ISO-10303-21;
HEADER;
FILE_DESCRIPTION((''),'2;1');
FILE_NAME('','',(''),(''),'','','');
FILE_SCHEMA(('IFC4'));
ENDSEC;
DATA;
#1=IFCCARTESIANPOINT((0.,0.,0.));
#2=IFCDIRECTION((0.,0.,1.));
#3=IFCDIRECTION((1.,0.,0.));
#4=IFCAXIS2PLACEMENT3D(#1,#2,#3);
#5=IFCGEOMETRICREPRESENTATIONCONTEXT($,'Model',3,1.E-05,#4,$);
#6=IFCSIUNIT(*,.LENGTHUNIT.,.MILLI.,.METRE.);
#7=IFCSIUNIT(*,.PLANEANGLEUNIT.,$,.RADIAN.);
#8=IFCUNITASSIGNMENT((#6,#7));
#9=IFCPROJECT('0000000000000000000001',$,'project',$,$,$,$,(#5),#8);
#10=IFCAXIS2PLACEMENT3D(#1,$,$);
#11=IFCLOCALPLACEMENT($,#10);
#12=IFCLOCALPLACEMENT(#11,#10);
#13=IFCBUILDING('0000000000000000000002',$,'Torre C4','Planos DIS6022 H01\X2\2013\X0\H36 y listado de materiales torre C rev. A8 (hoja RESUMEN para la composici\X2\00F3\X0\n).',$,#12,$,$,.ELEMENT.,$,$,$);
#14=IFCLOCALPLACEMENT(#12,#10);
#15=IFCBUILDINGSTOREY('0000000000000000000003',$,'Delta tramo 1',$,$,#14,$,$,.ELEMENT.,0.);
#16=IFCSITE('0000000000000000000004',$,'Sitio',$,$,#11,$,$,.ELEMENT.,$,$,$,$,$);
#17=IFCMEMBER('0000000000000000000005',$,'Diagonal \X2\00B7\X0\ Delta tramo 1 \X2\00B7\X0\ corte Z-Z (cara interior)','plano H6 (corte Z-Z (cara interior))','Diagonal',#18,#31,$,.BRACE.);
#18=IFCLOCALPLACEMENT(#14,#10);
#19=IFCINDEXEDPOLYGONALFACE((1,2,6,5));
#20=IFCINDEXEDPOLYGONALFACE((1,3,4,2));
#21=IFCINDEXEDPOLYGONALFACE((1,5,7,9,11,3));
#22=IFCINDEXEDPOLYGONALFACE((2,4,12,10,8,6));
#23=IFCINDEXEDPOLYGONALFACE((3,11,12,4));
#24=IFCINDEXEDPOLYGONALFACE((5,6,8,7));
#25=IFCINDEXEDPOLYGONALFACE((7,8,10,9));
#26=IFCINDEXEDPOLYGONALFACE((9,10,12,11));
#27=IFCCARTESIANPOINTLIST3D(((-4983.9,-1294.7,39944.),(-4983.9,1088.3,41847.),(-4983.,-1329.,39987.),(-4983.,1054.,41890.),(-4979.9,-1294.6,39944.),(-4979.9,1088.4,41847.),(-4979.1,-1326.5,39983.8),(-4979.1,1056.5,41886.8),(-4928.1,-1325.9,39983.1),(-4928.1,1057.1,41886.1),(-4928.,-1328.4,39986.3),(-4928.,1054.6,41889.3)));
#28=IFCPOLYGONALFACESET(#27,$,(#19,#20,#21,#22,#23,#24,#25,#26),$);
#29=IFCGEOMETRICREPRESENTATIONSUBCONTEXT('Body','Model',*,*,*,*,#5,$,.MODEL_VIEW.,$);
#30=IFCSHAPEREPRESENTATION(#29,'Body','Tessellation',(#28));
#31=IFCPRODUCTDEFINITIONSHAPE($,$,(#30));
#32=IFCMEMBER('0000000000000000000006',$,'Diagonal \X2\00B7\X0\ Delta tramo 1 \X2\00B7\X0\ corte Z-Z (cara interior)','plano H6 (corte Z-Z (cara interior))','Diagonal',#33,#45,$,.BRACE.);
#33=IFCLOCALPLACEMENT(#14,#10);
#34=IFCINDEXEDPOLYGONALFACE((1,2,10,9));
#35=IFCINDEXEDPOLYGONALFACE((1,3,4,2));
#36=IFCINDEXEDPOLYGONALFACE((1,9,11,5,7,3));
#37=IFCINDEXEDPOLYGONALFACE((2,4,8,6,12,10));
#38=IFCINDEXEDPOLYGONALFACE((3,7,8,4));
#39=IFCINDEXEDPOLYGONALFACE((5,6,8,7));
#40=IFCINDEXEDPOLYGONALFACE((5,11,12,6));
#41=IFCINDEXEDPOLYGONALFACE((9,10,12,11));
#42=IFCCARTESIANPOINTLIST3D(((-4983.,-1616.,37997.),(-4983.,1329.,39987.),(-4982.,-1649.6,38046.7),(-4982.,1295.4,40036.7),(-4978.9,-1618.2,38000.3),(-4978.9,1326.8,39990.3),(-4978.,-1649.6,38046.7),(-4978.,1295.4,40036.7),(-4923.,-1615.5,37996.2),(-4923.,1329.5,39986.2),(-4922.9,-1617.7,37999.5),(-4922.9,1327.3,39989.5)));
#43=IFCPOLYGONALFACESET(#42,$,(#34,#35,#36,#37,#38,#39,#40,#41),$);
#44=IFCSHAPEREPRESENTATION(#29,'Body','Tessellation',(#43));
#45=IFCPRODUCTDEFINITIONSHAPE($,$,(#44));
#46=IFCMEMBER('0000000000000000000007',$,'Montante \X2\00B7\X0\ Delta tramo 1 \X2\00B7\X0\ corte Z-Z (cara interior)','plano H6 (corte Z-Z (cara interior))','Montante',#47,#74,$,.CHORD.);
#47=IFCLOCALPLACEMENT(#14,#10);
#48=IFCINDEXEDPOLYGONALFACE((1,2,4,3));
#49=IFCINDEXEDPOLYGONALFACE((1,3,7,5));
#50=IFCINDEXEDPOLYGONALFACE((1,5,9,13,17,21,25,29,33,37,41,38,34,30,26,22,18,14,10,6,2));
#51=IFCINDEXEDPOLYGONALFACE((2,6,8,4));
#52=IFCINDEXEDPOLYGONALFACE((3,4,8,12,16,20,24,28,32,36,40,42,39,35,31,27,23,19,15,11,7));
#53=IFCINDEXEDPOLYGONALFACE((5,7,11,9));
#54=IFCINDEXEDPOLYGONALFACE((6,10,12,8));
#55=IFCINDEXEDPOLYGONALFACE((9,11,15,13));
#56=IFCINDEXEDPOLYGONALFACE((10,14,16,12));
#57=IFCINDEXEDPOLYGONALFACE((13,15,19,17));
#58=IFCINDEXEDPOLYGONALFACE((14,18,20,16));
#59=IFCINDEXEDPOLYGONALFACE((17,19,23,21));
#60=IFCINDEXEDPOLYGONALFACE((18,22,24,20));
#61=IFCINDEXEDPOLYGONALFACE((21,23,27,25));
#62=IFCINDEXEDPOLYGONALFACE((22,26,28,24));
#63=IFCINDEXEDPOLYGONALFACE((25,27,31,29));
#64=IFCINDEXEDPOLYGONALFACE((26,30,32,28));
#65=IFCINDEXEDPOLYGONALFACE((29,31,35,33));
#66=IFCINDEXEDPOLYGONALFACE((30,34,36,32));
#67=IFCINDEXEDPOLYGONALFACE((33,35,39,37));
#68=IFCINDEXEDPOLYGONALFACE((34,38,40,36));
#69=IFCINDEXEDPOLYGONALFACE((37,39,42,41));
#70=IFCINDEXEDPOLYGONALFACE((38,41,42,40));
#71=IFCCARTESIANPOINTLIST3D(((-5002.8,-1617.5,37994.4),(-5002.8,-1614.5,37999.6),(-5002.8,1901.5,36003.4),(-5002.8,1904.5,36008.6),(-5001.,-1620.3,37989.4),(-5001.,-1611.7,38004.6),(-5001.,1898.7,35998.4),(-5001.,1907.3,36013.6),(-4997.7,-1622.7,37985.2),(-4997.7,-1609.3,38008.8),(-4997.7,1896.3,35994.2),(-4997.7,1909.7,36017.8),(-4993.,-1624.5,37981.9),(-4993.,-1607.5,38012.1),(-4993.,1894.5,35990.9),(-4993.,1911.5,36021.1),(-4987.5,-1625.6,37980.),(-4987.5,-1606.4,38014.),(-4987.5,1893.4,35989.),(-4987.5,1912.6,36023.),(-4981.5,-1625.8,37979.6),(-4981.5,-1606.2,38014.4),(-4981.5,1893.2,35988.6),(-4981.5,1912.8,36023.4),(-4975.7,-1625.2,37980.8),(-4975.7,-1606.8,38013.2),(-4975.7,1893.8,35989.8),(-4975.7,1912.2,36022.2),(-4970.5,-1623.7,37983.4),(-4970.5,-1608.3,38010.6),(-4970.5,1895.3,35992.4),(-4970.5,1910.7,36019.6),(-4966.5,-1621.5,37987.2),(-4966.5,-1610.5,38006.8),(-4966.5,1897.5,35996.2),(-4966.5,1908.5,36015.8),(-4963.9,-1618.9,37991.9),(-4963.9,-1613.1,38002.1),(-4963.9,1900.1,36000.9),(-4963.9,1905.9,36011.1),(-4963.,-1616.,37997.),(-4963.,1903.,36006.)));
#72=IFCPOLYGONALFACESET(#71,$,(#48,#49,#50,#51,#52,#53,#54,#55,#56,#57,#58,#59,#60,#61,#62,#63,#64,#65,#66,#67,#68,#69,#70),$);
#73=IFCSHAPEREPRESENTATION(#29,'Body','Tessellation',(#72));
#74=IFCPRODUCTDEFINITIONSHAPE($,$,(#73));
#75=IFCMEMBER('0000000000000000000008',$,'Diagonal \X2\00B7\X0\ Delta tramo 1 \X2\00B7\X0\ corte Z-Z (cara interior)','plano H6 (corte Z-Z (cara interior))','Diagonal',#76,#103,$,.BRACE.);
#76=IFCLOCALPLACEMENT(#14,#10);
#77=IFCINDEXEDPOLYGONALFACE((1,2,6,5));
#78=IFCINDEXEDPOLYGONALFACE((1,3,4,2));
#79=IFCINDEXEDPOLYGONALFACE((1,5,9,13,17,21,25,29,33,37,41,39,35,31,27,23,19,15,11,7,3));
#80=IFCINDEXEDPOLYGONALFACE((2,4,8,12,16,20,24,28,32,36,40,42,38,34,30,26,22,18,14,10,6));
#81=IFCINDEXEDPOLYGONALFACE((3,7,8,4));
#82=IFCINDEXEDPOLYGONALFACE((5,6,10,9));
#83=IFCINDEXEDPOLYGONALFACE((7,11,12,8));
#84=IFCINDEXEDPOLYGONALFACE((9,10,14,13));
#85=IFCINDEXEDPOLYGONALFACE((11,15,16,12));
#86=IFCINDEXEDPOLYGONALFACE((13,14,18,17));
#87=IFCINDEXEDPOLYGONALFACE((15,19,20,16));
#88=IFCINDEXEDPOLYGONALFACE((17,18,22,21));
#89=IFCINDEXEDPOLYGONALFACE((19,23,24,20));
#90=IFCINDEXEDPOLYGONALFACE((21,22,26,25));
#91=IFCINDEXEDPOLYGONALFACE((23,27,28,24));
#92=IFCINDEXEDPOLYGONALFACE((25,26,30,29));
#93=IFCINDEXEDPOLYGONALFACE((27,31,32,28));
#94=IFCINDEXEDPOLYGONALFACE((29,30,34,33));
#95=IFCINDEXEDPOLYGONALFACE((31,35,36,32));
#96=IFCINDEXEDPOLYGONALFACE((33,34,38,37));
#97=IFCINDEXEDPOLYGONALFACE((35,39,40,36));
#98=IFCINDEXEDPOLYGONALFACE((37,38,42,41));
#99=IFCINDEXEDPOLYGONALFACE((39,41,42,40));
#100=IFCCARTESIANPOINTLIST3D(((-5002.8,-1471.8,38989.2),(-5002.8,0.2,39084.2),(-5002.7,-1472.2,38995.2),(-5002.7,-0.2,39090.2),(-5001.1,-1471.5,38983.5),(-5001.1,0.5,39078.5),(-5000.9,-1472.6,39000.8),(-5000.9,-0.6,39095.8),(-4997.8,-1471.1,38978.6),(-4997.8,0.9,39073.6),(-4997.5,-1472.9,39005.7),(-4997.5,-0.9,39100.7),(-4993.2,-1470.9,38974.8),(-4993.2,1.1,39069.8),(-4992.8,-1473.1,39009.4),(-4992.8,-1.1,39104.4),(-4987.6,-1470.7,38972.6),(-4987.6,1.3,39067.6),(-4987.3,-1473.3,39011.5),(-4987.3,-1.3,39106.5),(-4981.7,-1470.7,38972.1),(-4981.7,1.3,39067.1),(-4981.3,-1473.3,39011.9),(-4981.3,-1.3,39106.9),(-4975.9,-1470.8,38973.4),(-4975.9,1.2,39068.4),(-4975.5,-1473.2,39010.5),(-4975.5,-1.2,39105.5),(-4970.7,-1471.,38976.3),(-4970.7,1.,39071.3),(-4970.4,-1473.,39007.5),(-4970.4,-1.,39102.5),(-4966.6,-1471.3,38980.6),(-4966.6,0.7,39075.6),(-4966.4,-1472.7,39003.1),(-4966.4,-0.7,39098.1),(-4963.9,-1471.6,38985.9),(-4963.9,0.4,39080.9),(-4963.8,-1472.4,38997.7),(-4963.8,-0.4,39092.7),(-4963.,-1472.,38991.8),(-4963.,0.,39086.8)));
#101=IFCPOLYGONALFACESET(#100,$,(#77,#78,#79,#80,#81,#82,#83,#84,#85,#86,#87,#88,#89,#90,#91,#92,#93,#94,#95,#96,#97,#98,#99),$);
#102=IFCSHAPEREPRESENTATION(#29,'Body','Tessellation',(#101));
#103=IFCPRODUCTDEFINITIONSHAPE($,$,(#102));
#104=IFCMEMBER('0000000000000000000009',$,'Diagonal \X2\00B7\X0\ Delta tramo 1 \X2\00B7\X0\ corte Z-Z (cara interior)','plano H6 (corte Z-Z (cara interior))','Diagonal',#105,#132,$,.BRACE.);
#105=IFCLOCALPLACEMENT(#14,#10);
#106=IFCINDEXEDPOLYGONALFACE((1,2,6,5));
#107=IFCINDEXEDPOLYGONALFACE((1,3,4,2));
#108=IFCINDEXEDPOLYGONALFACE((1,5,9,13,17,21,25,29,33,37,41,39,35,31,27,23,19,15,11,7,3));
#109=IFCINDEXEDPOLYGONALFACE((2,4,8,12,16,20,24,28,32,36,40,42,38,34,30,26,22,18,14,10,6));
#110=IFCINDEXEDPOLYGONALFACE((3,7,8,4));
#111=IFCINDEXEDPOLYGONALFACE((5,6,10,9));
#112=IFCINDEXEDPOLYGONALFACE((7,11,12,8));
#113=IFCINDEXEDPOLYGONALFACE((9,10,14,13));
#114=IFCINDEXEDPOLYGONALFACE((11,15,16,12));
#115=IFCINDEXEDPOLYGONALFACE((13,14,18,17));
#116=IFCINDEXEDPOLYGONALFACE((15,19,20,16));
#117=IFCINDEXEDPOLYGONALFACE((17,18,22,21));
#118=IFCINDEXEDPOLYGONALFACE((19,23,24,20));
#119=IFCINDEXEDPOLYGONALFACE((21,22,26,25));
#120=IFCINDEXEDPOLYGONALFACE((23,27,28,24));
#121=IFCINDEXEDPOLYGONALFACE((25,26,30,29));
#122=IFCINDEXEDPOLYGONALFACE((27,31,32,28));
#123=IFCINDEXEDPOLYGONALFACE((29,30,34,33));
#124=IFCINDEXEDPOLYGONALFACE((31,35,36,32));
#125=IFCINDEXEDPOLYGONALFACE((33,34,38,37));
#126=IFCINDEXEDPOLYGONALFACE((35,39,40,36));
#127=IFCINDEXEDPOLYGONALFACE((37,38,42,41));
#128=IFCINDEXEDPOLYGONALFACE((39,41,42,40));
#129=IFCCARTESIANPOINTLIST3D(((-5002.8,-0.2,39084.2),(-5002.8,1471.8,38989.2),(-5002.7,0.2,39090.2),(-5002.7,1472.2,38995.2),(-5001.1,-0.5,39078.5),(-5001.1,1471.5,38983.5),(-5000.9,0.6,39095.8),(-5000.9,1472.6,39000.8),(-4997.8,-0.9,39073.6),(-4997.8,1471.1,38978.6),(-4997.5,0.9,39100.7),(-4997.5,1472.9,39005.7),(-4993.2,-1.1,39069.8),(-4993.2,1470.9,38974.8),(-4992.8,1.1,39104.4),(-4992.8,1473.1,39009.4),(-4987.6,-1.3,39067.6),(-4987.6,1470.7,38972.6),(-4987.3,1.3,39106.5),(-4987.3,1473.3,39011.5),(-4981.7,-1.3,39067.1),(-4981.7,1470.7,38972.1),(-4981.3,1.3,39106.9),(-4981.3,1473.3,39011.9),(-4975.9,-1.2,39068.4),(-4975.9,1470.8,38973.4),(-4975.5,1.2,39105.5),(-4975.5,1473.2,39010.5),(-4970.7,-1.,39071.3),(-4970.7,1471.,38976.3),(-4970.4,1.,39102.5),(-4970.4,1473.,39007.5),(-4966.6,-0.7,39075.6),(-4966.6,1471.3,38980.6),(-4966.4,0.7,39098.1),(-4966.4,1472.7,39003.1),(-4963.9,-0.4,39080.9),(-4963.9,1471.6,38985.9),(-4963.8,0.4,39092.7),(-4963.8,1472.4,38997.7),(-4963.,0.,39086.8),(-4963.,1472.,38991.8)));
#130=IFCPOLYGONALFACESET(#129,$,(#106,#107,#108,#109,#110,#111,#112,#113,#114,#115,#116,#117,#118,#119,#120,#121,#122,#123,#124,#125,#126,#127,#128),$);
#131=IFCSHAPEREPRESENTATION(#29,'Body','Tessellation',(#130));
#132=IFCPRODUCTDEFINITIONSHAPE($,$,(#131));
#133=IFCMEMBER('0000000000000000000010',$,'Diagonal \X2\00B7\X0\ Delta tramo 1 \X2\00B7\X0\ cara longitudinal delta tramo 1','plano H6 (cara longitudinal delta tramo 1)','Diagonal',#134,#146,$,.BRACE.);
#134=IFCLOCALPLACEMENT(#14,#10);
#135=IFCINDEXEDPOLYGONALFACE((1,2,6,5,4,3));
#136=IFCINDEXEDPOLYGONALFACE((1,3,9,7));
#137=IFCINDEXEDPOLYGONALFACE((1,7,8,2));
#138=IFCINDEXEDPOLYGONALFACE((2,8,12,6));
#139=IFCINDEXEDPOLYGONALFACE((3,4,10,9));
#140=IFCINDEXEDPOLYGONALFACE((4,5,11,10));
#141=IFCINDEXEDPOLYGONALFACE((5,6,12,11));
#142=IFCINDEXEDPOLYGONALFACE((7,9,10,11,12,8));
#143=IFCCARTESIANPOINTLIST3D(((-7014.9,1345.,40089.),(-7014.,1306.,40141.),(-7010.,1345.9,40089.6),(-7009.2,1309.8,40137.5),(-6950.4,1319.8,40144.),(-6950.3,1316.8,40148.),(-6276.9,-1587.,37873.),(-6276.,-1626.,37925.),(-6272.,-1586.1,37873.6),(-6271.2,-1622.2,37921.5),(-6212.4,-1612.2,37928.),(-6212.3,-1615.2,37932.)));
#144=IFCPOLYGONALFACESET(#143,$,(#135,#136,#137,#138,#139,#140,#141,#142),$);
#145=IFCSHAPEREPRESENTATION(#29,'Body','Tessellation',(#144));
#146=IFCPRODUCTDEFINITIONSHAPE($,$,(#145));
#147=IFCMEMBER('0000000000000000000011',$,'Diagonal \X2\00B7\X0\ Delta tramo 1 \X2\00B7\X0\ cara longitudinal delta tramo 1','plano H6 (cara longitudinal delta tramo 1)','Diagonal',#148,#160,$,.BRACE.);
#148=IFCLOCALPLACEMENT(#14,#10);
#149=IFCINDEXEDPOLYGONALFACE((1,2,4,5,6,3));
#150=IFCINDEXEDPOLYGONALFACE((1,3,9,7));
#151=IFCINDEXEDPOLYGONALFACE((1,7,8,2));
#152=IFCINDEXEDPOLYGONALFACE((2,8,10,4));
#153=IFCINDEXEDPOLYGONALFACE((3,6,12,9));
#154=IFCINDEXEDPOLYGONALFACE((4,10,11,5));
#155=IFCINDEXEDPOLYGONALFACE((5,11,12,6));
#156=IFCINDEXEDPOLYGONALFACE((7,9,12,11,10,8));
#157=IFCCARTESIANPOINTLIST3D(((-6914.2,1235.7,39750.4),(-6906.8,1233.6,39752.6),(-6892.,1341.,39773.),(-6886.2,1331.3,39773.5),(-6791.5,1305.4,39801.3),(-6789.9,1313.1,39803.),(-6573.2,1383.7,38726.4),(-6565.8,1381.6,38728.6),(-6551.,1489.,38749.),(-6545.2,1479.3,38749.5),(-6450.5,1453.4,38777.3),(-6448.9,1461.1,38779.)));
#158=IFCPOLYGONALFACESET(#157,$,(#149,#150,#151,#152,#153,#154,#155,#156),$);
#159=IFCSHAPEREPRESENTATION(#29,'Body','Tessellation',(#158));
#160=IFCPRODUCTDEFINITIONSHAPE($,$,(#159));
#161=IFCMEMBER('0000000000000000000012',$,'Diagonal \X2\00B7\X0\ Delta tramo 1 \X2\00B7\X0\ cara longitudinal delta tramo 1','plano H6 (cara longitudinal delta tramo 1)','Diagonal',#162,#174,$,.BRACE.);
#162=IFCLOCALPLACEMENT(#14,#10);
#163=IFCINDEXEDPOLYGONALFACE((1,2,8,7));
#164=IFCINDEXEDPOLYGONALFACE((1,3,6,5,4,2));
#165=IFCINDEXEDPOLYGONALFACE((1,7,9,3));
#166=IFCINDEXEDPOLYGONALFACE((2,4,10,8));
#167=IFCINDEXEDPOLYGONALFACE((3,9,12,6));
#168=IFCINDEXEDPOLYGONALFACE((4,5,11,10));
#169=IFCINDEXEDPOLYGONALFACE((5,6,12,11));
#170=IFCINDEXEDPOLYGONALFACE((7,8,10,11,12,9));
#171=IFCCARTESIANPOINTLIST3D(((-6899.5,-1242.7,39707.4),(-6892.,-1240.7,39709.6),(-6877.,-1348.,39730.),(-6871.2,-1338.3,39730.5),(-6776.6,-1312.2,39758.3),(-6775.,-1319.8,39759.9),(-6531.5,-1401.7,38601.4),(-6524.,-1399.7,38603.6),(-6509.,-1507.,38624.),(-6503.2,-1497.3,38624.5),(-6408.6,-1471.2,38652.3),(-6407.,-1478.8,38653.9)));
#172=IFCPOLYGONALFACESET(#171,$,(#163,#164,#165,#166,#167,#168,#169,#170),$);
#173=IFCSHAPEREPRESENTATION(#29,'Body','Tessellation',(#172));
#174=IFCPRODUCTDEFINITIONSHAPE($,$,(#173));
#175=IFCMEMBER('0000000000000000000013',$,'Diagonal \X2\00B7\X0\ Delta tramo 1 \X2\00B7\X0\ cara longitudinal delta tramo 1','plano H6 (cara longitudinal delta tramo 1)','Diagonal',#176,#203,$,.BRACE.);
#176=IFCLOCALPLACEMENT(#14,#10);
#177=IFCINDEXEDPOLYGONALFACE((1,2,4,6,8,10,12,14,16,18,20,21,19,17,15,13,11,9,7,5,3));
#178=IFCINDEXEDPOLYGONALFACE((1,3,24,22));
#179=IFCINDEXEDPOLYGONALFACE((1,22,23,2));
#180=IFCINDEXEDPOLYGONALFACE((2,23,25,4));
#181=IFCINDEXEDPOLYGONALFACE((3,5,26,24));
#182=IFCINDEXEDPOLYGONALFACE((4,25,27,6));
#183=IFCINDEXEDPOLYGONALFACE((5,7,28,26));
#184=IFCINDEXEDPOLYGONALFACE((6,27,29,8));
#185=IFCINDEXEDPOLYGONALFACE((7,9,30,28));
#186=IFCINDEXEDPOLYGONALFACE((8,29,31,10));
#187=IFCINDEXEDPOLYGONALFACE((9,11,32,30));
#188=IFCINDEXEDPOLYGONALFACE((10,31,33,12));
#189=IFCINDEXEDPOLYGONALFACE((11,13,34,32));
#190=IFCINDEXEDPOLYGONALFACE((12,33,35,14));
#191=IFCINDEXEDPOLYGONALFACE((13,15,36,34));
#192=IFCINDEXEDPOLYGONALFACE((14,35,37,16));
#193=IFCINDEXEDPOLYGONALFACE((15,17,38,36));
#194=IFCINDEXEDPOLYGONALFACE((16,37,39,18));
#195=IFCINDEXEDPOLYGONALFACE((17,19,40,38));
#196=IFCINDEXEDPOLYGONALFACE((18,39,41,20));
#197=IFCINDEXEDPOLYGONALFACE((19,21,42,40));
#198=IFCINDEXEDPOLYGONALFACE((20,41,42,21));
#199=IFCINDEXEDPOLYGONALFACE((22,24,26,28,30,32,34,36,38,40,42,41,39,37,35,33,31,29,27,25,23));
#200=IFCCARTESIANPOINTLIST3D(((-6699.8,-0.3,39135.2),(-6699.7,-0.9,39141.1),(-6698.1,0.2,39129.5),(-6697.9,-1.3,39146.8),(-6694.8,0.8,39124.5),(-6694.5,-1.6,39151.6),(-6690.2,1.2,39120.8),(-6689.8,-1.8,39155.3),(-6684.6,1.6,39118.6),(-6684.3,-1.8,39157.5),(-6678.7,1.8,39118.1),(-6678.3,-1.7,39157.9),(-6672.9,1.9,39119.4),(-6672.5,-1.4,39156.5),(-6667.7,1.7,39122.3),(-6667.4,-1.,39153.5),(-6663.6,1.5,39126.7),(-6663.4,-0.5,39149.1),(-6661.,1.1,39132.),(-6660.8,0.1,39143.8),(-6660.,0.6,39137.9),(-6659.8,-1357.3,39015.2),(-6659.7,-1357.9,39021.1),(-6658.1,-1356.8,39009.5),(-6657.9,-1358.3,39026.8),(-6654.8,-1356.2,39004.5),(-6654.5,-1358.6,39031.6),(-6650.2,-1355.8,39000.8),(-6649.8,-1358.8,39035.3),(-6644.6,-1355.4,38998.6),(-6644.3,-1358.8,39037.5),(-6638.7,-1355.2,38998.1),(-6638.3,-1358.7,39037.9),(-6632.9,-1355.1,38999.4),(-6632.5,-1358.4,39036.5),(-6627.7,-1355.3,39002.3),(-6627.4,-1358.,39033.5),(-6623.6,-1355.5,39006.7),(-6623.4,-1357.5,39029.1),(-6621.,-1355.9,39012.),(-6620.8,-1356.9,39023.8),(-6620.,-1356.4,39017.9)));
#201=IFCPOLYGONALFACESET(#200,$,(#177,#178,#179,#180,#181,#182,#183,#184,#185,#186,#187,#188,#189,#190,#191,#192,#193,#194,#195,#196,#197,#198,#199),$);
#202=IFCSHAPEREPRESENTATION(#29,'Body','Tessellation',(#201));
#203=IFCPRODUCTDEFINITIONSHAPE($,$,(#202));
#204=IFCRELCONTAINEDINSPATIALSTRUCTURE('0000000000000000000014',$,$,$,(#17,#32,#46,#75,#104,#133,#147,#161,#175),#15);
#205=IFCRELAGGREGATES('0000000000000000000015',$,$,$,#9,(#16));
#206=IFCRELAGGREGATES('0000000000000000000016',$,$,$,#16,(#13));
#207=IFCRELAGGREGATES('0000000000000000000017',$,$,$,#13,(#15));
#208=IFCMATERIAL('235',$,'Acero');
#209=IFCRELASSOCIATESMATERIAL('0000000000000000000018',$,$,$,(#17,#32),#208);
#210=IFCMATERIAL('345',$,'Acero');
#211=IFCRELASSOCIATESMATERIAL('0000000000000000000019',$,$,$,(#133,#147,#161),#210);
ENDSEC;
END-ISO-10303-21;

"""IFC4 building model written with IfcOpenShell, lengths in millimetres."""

from ifc_helpers import new_model, si_unit, frame, frame_2d, origin, origin_with_axes, place, context, subcontext, project, spatial, circle, l_section, extrude, material, element, save


model = new_model("IFC4")

# Units and contexts
model_context = context("Model", 3, precision=1e-05, world=origin_with_axes())
body_context = subcontext(model_context, "Body", "Model", "MODEL_VIEW")
ifc_project = project(units=[si_unit("LENGTHUNIT", "METRE", prefix="MILLI"), si_unit("PLANEANGLEUNIT", "RADIAN")], contexts=[model_context])

# Site, building, storey
site_placement = place(None, origin())
site = spatial("IfcSite", under=ifc_project, at=site_placement, Name="Sitio", CompositionType="ELEMENT")
building_placement = place(site_placement, origin())
building = spatial("IfcBuilding", under=site, at=building_placement, Name="Torre C4", Description="Planos DIS6022 H01–H36 y listado de materiales torre C rev. A8 (hoja RESUMEN para la composición).", CompositionType="ELEMENT")
storey_placement = place(building_placement, origin())
storey = spatial("IfcBuildingStorey", under=building, at=storey_placement, Name="Delta tramo 1", CompositionType="ELEMENT", Elevation=0.0)

# Members
ifc_material_1 = material(Name="345", Category="Acero")
ifc_material_2 = material(Name="235", Category="Acero")
member_1_placement = place(storey_placement, frame((-4983.0, -1329.0, 39987.0), z_axis=(0.0, 0.781412, 0.624015), x_axis=(0.999852, 0.010743, -0.013453)))
element("IfcMember", 1, at=member_1_placement, inside=storey, material=ifc_material_2, Name="Diagonal · Delta tramo 1 · corte Z-Z (cara interior)", Description="plano H6 (corte Z-Z (cara interior))", ObjectType="Diagonal", PredefinedType="BRACE", context=body_context, shape_type="SweptSolid", body=[
    extrude(l_section(Depth=55.0, Width=55.0, Thickness=4.0, at=frame_2d((27.5, 27.5))), None, (0.0, 0.0, 1.0), 3049.6),
])
member_2_placement = place(storey_placement, frame((-4983.0, 1329.0, 39987.0), z_axis=(0.0, -0.828571, -0.559884), x_axis=(0.99987, 0.009026, -0.013358)))
element("IfcMember", 2, at=member_2_placement, inside=storey, material=ifc_material_2, Name="Diagonal · Delta tramo 1 · corte Z-Z (cara interior)", Description="plano H6 (corte Z-Z (cara interior))", ObjectType="Diagonal", PredefinedType="BRACE", context=body_context, shape_type="SweptSolid", body=[
    extrude(l_section(Depth=60.0, Width=60.0, Thickness=4.0, at=frame_2d((30.0, 30.0))), None, (0.0, 0.0, 1.0), 3554.3),
])
member_3_placement = place(storey_placement, frame((-4983.0, -1616.0, 37997.0), z_axis=(0.0, 0.870351, -0.492432), x_axis=(1.0, 0.0, 0.0)))
element("IfcMember", 3, at=member_3_placement, inside=storey, Name="Montante · Delta tramo 1 · corte Z-Z (cara interior)", Description="plano H6 (corte Z-Z (cara interior))", ObjectType="Montante", PredefinedType="CHORD", context=body_context, shape_type="SweptSolid", body=[
    extrude(circle(Radius=20.0), None, (0.0, 0.0, 1.0), 4043.2),
])
for number, where, z_axis, x_axis, name in (
    (4, (-4983.0, -1472.0, 38992.0), (0.0, 0.997924, 0.064404), (0.999955, 0.000613, -0.009492), "Diagonal · Delta tramo 1 · corte Z-Z (cara interior)"),
    (5, (-4983.0, 1472.0, 38992.0), (0.0, -0.997924, 0.064404), (0.999955, -0.000613, -0.009492), "Diagonal · Delta tramo 1 · corte Z-Z (cara interior)"),
):
    element("IfcMember", number, at=place(storey_placement, frame(where, z_axis=z_axis, x_axis=x_axis)), inside=storey, Name=name, Description="plano H6 (corte Z-Z (cara interior))", ObjectType="Diagonal", PredefinedType="BRACE", context=body_context, shape_type="SweptSolid", body=[
        extrude(circle(Radius=20.0), None, (0.0, 0.0, 1.0), 1475.1),
    ])
member_4_placement = place(storey_placement, frame((-6276.0, -1626.0, 37925.0), z_axis=(-0.196874, 0.782161, 0.591156), x_axis=(0.980322, 0.165937, 0.106927)))
element("IfcMember", 6, at=member_4_placement, inside=storey, material=ifc_material_1, Name="Diagonal · Delta tramo 1 · cara longitudinal delta tramo 1", Description="plano H6 (cara longitudinal delta tramo 1)", ObjectType="Diagonal", PredefinedType="BRACE", context=body_context, shape_type="SweptSolid", body=[
    extrude(l_section(Depth=65.0, Width=65.0, Thickness=5.0, at=frame_2d((32.5, 32.5))), None, (0.0, 0.0, 1.0), 3748.6),
])
member_5_placement = place(storey_placement, frame((-6892.0, 1341.0, 39773.0), z_axis=(0.31302, 0.135856, -0.939979), x_axis=(0.928102, -0.253844, 0.272377)))
element("IfcMember", 7, at=member_5_placement, inside=storey, material=ifc_material_1, Name="Diagonal · Delta tramo 1 · cara longitudinal delta tramo 1", Description="plano H6 (cara longitudinal delta tramo 1)", ObjectType="Diagonal", PredefinedType="BRACE", context=body_context, shape_type="SweptSolid", body=[
    extrude(l_section(Depth=110.0, Width=110.0, Thickness=8.0, at=frame_2d((55.0, 55.0))), None, (0.0, 0.0, 1.0), 1089.4),
])
member_6_placement = place(storey_placement, frame((-6509.0, -1507.0, 38624.0), z_axis=(-0.312816, 0.135157, 0.940148), x_axis=(0.927617, 0.25621, 0.271813)))
element("IfcMember", 8, at=member_6_placement, inside=storey, material=ifc_material_1, Name="Diagonal · Delta tramo 1 · cara longitudinal delta tramo 1", Description="plano H6 (cara longitudinal delta tramo 1)", ObjectType="Diagonal", PredefinedType="BRACE", context=body_context, shape_type="SweptSolid", body=[
    extrude(l_section(Depth=110.0, Width=110.0, Thickness=8.0, at=frame_2d((55.0, 55.0))), None, (0.0, 0.0, 1.0), 1176.4),
])
for number, where, z_axis, x_axis, name in (
    (9, (-6680.0, 0.0, 39138.0), (0.02935, -0.995684, -0.088049), (0.999529, 0.030023, -0.006331), "Diagonal · Delta tramo 1 · cara longitudinal delta tramo 1"),
):
    element("IfcMember", number, at=place(storey_placement, frame(where, z_axis=z_axis, x_axis=x_axis)), inside=storey, Name=name, Description="plano H6 (cara longitudinal delta tramo 1)", ObjectType="Diagonal", PredefinedType="BRACE", context=body_context, shape_type="SweptSolid", body=[
        extrude(circle(Radius=20.0), None, (0.0, 0.0, 1.0), 1362.9),
    ])

save(model, "model.ifc")
